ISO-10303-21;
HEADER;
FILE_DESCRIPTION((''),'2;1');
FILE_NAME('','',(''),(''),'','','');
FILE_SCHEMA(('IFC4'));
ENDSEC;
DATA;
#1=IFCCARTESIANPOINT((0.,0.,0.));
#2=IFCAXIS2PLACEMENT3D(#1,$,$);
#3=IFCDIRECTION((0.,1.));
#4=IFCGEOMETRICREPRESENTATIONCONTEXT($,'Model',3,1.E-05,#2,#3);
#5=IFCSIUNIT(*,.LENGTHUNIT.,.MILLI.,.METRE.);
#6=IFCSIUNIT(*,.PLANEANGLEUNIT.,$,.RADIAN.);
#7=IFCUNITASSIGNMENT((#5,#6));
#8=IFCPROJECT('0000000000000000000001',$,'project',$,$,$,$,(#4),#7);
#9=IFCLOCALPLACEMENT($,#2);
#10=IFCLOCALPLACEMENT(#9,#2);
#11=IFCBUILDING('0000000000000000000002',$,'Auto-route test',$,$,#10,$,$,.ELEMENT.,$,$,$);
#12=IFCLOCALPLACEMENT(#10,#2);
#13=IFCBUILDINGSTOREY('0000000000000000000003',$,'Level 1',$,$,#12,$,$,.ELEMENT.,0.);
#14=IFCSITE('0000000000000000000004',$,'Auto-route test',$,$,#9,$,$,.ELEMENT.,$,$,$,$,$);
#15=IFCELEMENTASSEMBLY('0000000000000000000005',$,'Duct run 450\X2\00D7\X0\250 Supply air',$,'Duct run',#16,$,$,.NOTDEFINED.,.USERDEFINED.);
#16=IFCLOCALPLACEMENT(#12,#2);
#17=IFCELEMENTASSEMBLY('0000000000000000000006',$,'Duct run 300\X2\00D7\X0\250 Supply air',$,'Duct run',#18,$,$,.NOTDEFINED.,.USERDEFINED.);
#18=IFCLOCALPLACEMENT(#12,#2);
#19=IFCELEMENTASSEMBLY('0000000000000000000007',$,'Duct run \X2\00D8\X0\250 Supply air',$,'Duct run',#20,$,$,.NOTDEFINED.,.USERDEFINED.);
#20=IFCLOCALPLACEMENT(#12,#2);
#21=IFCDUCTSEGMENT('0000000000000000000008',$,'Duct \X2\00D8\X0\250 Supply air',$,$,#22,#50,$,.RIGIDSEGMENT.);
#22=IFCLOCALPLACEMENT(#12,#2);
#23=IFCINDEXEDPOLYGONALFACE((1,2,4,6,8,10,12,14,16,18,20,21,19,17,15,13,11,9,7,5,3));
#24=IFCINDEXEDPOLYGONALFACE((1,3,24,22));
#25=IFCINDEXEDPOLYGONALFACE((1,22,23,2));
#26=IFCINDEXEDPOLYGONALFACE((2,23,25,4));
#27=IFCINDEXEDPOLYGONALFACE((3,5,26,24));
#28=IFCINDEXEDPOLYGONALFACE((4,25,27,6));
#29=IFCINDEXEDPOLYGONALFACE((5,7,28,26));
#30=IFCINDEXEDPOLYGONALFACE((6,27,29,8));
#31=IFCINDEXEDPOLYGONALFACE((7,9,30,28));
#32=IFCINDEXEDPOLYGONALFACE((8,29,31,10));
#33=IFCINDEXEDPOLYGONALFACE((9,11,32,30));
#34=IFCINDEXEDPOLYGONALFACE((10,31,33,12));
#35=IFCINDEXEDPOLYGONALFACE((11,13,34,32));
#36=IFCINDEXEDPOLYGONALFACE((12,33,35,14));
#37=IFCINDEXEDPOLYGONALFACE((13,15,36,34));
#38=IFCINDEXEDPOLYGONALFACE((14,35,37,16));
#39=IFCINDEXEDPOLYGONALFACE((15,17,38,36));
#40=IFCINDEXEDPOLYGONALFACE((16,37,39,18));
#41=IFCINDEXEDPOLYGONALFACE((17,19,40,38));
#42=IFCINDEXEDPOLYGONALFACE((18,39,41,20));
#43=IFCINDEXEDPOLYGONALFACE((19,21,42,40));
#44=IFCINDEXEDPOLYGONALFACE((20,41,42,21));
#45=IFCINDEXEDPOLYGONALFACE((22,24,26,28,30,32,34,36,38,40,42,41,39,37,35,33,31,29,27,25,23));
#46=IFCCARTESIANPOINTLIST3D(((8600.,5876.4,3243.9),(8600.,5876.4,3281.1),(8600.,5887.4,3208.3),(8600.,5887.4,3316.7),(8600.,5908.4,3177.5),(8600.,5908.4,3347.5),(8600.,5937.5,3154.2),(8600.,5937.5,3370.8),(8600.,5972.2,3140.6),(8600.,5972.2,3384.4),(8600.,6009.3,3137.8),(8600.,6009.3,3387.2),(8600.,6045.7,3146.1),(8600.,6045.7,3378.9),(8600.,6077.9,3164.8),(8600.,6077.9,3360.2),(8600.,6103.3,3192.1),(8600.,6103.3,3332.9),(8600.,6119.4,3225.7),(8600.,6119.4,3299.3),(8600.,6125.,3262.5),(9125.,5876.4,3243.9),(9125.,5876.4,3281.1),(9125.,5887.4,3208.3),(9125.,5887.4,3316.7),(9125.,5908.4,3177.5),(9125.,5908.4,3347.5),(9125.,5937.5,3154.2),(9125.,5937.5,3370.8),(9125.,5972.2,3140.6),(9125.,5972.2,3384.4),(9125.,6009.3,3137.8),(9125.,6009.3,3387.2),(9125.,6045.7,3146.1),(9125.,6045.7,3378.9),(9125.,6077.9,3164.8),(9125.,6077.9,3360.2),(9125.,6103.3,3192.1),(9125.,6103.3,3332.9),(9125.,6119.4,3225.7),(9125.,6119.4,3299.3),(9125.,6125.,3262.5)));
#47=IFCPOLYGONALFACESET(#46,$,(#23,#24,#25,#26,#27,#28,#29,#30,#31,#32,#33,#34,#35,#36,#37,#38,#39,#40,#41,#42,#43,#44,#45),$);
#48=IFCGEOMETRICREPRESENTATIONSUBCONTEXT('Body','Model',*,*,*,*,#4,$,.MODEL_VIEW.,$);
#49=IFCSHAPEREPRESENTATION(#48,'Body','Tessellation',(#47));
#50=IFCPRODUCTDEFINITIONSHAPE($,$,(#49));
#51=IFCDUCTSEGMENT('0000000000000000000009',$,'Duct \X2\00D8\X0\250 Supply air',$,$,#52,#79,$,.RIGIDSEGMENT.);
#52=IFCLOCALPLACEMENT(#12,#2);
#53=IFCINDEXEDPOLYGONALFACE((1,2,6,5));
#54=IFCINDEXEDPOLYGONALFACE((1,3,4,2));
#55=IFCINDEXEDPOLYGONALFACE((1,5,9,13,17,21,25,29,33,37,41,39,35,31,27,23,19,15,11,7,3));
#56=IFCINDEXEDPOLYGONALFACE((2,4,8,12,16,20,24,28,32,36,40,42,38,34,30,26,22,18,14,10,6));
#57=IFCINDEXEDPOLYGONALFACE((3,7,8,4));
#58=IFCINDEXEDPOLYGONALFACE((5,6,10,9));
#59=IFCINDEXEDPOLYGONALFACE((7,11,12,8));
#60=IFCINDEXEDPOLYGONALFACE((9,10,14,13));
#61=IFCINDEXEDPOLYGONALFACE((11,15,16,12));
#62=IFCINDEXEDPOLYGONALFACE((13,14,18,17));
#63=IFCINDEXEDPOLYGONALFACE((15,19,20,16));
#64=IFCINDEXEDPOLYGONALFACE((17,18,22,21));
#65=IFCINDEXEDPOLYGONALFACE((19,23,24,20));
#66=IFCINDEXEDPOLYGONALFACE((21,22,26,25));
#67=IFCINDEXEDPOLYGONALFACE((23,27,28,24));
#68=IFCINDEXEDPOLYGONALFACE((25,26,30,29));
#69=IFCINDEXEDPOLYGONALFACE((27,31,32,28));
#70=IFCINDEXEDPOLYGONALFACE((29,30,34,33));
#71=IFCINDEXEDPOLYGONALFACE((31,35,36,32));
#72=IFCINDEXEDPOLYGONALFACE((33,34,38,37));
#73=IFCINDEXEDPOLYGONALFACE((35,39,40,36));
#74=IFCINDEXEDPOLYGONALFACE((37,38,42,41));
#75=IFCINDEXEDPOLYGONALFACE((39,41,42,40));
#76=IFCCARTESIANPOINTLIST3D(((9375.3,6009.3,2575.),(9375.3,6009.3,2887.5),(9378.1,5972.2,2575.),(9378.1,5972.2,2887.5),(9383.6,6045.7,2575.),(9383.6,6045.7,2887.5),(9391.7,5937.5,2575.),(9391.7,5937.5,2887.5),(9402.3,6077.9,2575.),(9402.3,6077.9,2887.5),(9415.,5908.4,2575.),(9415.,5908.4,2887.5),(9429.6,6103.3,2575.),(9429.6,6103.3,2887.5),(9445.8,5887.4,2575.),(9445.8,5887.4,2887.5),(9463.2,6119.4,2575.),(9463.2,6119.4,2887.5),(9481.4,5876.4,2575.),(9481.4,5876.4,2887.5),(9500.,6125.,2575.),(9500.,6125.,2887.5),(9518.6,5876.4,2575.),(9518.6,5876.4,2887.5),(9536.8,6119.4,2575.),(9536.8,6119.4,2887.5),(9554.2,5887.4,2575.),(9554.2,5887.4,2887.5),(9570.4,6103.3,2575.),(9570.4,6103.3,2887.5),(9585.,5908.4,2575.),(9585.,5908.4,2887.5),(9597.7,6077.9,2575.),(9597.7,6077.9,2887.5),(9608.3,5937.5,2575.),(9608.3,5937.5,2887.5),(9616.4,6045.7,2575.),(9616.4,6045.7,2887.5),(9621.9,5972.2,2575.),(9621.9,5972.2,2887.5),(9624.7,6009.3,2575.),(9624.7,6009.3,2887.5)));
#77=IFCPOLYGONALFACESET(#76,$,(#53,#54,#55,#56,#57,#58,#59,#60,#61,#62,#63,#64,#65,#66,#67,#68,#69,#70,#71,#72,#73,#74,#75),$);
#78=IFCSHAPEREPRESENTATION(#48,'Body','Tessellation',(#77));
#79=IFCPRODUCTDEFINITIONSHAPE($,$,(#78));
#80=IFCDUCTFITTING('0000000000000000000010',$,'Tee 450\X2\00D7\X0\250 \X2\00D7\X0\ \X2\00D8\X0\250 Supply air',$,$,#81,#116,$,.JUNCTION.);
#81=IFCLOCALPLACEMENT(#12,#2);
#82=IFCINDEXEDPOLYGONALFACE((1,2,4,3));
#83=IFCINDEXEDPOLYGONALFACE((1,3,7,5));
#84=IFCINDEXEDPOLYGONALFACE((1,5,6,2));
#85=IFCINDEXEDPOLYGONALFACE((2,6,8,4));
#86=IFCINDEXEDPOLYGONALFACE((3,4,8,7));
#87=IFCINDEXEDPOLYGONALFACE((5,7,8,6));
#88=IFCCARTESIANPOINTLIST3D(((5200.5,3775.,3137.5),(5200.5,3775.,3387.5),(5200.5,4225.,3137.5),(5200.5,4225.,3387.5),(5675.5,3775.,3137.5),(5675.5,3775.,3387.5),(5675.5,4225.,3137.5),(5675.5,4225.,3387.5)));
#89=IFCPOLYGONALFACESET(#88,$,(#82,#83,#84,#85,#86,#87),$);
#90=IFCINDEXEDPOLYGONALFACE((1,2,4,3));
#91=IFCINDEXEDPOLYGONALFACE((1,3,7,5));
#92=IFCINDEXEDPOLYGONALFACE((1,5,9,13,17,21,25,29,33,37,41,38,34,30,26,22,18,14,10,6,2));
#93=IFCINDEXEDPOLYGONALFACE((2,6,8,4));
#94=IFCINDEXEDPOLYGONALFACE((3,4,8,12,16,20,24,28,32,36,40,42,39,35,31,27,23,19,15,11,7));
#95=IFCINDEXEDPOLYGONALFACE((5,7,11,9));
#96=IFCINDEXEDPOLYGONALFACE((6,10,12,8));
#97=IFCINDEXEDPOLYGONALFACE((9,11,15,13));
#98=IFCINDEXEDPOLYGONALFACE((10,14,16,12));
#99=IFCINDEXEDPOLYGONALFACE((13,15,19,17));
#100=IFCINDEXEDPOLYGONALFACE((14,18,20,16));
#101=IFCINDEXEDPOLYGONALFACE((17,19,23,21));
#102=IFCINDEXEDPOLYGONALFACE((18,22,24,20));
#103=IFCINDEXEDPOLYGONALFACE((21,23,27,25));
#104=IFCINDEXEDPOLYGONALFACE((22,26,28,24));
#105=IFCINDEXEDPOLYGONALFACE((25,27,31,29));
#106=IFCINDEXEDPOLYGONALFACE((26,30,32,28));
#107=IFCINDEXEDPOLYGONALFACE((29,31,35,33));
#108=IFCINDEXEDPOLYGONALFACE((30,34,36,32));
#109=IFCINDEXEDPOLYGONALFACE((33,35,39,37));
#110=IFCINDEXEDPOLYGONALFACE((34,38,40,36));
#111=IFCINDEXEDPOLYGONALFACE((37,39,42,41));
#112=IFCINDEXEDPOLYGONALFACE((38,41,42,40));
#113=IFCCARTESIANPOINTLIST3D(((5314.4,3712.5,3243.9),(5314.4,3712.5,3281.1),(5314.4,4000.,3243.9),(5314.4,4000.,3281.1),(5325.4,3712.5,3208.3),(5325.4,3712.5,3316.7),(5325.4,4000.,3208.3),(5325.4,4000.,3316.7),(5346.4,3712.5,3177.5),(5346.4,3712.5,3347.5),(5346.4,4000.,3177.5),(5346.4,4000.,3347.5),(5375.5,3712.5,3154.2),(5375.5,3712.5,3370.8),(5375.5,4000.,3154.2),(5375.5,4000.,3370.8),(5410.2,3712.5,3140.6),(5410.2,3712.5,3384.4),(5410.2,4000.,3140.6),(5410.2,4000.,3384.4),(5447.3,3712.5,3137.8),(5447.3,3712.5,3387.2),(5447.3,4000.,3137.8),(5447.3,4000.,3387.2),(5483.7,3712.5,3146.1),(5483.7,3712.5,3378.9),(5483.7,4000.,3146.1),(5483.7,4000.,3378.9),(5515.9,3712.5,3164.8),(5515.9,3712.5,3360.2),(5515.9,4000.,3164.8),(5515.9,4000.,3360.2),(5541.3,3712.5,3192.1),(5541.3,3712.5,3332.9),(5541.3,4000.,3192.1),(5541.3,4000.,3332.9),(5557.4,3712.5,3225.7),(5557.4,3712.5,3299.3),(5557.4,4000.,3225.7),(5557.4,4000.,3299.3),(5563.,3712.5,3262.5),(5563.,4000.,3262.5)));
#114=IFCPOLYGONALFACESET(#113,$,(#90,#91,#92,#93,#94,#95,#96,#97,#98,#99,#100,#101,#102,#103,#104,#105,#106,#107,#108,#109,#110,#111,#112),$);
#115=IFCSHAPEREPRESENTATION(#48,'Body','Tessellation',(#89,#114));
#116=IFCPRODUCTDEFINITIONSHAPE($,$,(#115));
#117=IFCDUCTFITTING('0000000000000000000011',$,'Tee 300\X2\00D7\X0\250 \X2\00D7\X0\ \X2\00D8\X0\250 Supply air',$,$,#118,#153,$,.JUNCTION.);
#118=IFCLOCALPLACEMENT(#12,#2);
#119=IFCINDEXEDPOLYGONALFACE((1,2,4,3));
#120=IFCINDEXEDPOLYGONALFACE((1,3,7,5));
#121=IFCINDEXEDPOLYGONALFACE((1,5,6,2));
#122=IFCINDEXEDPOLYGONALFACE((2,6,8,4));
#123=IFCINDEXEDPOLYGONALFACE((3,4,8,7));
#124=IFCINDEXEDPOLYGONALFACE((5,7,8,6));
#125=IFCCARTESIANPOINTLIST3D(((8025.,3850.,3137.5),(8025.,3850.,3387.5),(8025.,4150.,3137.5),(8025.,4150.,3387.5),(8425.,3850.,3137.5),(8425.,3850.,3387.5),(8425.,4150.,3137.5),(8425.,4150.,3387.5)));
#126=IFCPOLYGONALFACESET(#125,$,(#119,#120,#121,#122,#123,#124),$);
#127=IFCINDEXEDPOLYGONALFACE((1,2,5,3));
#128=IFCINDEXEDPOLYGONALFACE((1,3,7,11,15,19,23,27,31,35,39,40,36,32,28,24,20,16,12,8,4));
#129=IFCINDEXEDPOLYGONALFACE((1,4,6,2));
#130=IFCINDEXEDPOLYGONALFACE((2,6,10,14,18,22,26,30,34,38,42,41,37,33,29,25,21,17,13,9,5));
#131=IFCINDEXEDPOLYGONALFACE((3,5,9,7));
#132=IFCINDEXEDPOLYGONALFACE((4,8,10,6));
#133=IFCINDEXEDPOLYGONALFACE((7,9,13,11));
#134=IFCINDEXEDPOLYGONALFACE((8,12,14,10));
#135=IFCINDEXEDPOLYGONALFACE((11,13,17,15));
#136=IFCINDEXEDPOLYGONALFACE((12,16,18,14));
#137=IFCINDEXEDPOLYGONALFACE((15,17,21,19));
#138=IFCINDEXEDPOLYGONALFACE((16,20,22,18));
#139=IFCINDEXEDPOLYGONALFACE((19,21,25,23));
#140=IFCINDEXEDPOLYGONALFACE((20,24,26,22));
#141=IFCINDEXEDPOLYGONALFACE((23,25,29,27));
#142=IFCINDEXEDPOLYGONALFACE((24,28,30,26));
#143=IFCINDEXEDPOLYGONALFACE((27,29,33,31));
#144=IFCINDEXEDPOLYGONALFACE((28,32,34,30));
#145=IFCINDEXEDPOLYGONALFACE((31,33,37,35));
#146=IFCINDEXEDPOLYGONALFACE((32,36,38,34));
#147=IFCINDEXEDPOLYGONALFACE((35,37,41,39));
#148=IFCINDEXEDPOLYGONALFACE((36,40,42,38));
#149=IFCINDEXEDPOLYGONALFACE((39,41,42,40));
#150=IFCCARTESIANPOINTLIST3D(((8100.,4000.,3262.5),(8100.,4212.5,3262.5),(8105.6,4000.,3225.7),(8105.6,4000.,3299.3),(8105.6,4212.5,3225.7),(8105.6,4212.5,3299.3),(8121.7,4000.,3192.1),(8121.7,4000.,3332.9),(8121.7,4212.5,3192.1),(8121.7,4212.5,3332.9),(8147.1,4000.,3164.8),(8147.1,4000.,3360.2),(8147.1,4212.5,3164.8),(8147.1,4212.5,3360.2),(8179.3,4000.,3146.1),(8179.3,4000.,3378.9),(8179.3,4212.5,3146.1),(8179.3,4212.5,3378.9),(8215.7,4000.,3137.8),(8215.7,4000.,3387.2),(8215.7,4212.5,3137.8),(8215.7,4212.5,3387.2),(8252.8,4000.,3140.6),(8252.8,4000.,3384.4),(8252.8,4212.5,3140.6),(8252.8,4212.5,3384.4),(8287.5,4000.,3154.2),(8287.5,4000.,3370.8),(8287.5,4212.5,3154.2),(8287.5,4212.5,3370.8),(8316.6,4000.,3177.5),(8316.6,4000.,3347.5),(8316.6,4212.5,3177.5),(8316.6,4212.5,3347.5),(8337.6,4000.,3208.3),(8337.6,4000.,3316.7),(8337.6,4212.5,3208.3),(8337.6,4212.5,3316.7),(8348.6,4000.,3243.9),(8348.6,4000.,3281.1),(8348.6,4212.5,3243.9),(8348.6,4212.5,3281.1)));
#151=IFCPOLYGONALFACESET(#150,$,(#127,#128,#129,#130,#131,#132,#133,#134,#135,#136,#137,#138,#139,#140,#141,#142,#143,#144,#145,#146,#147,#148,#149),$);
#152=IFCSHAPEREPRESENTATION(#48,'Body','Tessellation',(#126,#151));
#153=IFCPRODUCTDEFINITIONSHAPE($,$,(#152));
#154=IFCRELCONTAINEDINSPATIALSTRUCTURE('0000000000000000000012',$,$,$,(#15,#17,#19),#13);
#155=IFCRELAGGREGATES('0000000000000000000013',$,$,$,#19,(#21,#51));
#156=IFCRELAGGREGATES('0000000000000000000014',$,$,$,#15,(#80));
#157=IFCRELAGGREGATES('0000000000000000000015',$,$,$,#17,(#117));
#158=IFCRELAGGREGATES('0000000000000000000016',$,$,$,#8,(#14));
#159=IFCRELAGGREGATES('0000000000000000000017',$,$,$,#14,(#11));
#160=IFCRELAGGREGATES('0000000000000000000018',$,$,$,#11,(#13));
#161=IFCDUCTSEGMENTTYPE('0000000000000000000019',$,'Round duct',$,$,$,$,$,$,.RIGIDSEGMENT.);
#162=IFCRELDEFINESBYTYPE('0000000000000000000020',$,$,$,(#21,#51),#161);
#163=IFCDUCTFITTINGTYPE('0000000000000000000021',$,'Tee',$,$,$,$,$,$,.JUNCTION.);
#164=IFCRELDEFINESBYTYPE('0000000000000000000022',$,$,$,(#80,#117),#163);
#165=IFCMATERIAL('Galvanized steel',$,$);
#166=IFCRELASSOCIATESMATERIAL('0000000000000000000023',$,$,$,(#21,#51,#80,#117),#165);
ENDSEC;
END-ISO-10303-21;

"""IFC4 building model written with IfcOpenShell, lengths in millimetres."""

from ifc_helpers import new_model, si_unit, direction, frame, origin, origin_with_axes, origin_2d, place, context, subcontext, project, spatial, rectangle, circle, extrude, material, type_object, element, aggregate, save


model = new_model("IFC4")

# Units and contexts
model_context = context("Model", 3, precision=1e-05, world=origin(), true_north=direction((0.0, 1.0)))
body_context = subcontext(model_context, "Body", "Model", "MODEL_VIEW")
ifc_project = project(units=[si_unit("LENGTHUNIT", "METRE", prefix="MILLI"), si_unit("PLANEANGLEUNIT", "RADIAN")], contexts=[model_context])

# Site, building, storey
site_placement = place(None, origin())
site = spatial("IfcSite", under=ifc_project, at=site_placement, Name="Auto-route test", CompositionType="ELEMENT")
building_placement = place(site_placement, origin())
building = spatial("IfcBuilding", under=site, at=building_placement, Name="Auto-route test", CompositionType="ELEMENT")
storey_placement = place(building_placement, origin())
storey = spatial("IfcBuildingStorey", under=building, at=storey_placement, Name="Level 1", CompositionType="ELEMENT", Elevation=0.0)

# Element assemblies
assembly_1_placement = place(storey_placement, origin_with_axes())
assembly_1 = element("IfcElementAssembly", 1, at=assembly_1_placement, inside=storey, Name="Duct run 450×250 Supply air", ObjectType="Duct run", AssemblyPlace="NOTDEFINED", PredefinedType="USERDEFINED")
ifc_material_1 = material(Name="Galvanized steel")
assembly_2_placement = place(storey_placement, origin_with_axes())
assembly_2 = element("IfcElementAssembly", 2, at=assembly_2_placement, inside=storey, Name="Duct run 300×250 Supply air", ObjectType="Duct run", AssemblyPlace="NOTDEFINED", PredefinedType="USERDEFINED")

# Element assembly
assembly_3_placement = place(storey_placement, origin_with_axes())
assembly_3 = element("IfcElementAssembly", 3, at=assembly_3_placement, inside=storey, Name="Duct run Ø250 Supply air", ObjectType="Duct run", AssemblyPlace="NOTDEFINED", PredefinedType="USERDEFINED")

# Duct segments
duct_segment_type_1 = type_object("IfcDuctSegmentType", Name="Round duct", PredefinedType="RIGIDSEGMENT")
duct_segment_1_placement = place(storey_placement, origin_with_axes())
duct_segment_1 = element("IfcDuctSegment", 4, at=duct_segment_1_placement, type_object=duct_segment_type_1, material=ifc_material_1, Name="Duct Ø250 Supply air", PredefinedType="RIGIDSEGMENT", context=body_context, shape_type="SweptSolid", body=[
    extrude(circle(Radius=125.0, at=origin_2d()), frame((8600.0, 6000.0, 3262.5), z_axis=(1.0, 0.0, 0.0), x_axis=(0.0, 1.0, 0.0)), (0.0, 0.0, 1.0), 525.0),
])
duct_segment_2_placement = place(storey_placement, origin_with_axes())
duct_segment_2 = element("IfcDuctSegment", 5, at=duct_segment_2_placement, type_object=duct_segment_type_1, material=ifc_material_1, Name="Duct Ø250 Supply air", PredefinedType="RIGIDSEGMENT", context=body_context, shape_type="SweptSolid", body=[
    extrude(circle(Radius=125.0, at=origin_2d()), frame((9500.0, 6000.0, 2887.5), z_axis=(0.0, 0.0, -1.0), x_axis=(0.0, 1.0, 0.0)), (0.0, 0.0, 1.0), 312.5),
])
aggregate(assembly_3, [duct_segment_1, duct_segment_2])

# Duct fittings
duct_fitting_type_1 = type_object("IfcDuctFittingType", Name="Tee", PredefinedType="JUNCTION")
duct_fitting_1_placement = place(storey_placement, origin_with_axes())
duct_fitting_1 = element("IfcDuctFitting", 6, at=duct_fitting_1_placement, type_object=duct_fitting_type_1, material=ifc_material_1, Name="Tee 450×250 × Ø250 Supply air", PredefinedType="JUNCTION", context=body_context, shape_type="SweptSolid", body=[
    extrude(rectangle(XDim=450.0, YDim=250.0, at=origin_2d()), frame((5200.5, 4000.0, 3262.5), z_axis=(1.0, 0.0, 0.0), x_axis=(0.0, 1.0, 0.0)), (0.0, 0.0, 1.0), 475.0),
    extrude(circle(Radius=125.0, at=origin_2d()), frame((5438.0, 4000.0, 3262.5), z_axis=(0.0, -1.0, 0.0), x_axis=(1.0, 0.0, 0.0)), (0.0, 0.0, 1.0), 287.5),
])
aggregate(assembly_1, [duct_fitting_1])
duct_fitting_2_placement = place(storey_placement, origin_with_axes())
duct_fitting_2 = element("IfcDuctFitting", 7, at=duct_fitting_2_placement, type_object=duct_fitting_type_1, material=ifc_material_1, Name="Tee 300×250 × Ø250 Supply air", PredefinedType="JUNCTION", context=body_context, shape_type="SweptSolid", body=[
    extrude(rectangle(XDim=300.0, YDim=250.0, at=origin_2d()), frame((8025.0, 4000.0, 3262.5), z_axis=(1.0, 0.0, 0.0), x_axis=(0.0, 1.0, 0.0)), (0.0, 0.0, 1.0), 400.0),
    extrude(circle(Radius=125.0, at=origin_2d()), frame((8225.0, 4000.0, 3262.5), z_axis=(0.0, 1.0, 0.0), x_axis=(-1.0, 0.0, 0.0)), (0.0, 0.0, 1.0), 212.5),
])
aggregate(assembly_2, [duct_fitting_2])

save(model, "model.ifc")
